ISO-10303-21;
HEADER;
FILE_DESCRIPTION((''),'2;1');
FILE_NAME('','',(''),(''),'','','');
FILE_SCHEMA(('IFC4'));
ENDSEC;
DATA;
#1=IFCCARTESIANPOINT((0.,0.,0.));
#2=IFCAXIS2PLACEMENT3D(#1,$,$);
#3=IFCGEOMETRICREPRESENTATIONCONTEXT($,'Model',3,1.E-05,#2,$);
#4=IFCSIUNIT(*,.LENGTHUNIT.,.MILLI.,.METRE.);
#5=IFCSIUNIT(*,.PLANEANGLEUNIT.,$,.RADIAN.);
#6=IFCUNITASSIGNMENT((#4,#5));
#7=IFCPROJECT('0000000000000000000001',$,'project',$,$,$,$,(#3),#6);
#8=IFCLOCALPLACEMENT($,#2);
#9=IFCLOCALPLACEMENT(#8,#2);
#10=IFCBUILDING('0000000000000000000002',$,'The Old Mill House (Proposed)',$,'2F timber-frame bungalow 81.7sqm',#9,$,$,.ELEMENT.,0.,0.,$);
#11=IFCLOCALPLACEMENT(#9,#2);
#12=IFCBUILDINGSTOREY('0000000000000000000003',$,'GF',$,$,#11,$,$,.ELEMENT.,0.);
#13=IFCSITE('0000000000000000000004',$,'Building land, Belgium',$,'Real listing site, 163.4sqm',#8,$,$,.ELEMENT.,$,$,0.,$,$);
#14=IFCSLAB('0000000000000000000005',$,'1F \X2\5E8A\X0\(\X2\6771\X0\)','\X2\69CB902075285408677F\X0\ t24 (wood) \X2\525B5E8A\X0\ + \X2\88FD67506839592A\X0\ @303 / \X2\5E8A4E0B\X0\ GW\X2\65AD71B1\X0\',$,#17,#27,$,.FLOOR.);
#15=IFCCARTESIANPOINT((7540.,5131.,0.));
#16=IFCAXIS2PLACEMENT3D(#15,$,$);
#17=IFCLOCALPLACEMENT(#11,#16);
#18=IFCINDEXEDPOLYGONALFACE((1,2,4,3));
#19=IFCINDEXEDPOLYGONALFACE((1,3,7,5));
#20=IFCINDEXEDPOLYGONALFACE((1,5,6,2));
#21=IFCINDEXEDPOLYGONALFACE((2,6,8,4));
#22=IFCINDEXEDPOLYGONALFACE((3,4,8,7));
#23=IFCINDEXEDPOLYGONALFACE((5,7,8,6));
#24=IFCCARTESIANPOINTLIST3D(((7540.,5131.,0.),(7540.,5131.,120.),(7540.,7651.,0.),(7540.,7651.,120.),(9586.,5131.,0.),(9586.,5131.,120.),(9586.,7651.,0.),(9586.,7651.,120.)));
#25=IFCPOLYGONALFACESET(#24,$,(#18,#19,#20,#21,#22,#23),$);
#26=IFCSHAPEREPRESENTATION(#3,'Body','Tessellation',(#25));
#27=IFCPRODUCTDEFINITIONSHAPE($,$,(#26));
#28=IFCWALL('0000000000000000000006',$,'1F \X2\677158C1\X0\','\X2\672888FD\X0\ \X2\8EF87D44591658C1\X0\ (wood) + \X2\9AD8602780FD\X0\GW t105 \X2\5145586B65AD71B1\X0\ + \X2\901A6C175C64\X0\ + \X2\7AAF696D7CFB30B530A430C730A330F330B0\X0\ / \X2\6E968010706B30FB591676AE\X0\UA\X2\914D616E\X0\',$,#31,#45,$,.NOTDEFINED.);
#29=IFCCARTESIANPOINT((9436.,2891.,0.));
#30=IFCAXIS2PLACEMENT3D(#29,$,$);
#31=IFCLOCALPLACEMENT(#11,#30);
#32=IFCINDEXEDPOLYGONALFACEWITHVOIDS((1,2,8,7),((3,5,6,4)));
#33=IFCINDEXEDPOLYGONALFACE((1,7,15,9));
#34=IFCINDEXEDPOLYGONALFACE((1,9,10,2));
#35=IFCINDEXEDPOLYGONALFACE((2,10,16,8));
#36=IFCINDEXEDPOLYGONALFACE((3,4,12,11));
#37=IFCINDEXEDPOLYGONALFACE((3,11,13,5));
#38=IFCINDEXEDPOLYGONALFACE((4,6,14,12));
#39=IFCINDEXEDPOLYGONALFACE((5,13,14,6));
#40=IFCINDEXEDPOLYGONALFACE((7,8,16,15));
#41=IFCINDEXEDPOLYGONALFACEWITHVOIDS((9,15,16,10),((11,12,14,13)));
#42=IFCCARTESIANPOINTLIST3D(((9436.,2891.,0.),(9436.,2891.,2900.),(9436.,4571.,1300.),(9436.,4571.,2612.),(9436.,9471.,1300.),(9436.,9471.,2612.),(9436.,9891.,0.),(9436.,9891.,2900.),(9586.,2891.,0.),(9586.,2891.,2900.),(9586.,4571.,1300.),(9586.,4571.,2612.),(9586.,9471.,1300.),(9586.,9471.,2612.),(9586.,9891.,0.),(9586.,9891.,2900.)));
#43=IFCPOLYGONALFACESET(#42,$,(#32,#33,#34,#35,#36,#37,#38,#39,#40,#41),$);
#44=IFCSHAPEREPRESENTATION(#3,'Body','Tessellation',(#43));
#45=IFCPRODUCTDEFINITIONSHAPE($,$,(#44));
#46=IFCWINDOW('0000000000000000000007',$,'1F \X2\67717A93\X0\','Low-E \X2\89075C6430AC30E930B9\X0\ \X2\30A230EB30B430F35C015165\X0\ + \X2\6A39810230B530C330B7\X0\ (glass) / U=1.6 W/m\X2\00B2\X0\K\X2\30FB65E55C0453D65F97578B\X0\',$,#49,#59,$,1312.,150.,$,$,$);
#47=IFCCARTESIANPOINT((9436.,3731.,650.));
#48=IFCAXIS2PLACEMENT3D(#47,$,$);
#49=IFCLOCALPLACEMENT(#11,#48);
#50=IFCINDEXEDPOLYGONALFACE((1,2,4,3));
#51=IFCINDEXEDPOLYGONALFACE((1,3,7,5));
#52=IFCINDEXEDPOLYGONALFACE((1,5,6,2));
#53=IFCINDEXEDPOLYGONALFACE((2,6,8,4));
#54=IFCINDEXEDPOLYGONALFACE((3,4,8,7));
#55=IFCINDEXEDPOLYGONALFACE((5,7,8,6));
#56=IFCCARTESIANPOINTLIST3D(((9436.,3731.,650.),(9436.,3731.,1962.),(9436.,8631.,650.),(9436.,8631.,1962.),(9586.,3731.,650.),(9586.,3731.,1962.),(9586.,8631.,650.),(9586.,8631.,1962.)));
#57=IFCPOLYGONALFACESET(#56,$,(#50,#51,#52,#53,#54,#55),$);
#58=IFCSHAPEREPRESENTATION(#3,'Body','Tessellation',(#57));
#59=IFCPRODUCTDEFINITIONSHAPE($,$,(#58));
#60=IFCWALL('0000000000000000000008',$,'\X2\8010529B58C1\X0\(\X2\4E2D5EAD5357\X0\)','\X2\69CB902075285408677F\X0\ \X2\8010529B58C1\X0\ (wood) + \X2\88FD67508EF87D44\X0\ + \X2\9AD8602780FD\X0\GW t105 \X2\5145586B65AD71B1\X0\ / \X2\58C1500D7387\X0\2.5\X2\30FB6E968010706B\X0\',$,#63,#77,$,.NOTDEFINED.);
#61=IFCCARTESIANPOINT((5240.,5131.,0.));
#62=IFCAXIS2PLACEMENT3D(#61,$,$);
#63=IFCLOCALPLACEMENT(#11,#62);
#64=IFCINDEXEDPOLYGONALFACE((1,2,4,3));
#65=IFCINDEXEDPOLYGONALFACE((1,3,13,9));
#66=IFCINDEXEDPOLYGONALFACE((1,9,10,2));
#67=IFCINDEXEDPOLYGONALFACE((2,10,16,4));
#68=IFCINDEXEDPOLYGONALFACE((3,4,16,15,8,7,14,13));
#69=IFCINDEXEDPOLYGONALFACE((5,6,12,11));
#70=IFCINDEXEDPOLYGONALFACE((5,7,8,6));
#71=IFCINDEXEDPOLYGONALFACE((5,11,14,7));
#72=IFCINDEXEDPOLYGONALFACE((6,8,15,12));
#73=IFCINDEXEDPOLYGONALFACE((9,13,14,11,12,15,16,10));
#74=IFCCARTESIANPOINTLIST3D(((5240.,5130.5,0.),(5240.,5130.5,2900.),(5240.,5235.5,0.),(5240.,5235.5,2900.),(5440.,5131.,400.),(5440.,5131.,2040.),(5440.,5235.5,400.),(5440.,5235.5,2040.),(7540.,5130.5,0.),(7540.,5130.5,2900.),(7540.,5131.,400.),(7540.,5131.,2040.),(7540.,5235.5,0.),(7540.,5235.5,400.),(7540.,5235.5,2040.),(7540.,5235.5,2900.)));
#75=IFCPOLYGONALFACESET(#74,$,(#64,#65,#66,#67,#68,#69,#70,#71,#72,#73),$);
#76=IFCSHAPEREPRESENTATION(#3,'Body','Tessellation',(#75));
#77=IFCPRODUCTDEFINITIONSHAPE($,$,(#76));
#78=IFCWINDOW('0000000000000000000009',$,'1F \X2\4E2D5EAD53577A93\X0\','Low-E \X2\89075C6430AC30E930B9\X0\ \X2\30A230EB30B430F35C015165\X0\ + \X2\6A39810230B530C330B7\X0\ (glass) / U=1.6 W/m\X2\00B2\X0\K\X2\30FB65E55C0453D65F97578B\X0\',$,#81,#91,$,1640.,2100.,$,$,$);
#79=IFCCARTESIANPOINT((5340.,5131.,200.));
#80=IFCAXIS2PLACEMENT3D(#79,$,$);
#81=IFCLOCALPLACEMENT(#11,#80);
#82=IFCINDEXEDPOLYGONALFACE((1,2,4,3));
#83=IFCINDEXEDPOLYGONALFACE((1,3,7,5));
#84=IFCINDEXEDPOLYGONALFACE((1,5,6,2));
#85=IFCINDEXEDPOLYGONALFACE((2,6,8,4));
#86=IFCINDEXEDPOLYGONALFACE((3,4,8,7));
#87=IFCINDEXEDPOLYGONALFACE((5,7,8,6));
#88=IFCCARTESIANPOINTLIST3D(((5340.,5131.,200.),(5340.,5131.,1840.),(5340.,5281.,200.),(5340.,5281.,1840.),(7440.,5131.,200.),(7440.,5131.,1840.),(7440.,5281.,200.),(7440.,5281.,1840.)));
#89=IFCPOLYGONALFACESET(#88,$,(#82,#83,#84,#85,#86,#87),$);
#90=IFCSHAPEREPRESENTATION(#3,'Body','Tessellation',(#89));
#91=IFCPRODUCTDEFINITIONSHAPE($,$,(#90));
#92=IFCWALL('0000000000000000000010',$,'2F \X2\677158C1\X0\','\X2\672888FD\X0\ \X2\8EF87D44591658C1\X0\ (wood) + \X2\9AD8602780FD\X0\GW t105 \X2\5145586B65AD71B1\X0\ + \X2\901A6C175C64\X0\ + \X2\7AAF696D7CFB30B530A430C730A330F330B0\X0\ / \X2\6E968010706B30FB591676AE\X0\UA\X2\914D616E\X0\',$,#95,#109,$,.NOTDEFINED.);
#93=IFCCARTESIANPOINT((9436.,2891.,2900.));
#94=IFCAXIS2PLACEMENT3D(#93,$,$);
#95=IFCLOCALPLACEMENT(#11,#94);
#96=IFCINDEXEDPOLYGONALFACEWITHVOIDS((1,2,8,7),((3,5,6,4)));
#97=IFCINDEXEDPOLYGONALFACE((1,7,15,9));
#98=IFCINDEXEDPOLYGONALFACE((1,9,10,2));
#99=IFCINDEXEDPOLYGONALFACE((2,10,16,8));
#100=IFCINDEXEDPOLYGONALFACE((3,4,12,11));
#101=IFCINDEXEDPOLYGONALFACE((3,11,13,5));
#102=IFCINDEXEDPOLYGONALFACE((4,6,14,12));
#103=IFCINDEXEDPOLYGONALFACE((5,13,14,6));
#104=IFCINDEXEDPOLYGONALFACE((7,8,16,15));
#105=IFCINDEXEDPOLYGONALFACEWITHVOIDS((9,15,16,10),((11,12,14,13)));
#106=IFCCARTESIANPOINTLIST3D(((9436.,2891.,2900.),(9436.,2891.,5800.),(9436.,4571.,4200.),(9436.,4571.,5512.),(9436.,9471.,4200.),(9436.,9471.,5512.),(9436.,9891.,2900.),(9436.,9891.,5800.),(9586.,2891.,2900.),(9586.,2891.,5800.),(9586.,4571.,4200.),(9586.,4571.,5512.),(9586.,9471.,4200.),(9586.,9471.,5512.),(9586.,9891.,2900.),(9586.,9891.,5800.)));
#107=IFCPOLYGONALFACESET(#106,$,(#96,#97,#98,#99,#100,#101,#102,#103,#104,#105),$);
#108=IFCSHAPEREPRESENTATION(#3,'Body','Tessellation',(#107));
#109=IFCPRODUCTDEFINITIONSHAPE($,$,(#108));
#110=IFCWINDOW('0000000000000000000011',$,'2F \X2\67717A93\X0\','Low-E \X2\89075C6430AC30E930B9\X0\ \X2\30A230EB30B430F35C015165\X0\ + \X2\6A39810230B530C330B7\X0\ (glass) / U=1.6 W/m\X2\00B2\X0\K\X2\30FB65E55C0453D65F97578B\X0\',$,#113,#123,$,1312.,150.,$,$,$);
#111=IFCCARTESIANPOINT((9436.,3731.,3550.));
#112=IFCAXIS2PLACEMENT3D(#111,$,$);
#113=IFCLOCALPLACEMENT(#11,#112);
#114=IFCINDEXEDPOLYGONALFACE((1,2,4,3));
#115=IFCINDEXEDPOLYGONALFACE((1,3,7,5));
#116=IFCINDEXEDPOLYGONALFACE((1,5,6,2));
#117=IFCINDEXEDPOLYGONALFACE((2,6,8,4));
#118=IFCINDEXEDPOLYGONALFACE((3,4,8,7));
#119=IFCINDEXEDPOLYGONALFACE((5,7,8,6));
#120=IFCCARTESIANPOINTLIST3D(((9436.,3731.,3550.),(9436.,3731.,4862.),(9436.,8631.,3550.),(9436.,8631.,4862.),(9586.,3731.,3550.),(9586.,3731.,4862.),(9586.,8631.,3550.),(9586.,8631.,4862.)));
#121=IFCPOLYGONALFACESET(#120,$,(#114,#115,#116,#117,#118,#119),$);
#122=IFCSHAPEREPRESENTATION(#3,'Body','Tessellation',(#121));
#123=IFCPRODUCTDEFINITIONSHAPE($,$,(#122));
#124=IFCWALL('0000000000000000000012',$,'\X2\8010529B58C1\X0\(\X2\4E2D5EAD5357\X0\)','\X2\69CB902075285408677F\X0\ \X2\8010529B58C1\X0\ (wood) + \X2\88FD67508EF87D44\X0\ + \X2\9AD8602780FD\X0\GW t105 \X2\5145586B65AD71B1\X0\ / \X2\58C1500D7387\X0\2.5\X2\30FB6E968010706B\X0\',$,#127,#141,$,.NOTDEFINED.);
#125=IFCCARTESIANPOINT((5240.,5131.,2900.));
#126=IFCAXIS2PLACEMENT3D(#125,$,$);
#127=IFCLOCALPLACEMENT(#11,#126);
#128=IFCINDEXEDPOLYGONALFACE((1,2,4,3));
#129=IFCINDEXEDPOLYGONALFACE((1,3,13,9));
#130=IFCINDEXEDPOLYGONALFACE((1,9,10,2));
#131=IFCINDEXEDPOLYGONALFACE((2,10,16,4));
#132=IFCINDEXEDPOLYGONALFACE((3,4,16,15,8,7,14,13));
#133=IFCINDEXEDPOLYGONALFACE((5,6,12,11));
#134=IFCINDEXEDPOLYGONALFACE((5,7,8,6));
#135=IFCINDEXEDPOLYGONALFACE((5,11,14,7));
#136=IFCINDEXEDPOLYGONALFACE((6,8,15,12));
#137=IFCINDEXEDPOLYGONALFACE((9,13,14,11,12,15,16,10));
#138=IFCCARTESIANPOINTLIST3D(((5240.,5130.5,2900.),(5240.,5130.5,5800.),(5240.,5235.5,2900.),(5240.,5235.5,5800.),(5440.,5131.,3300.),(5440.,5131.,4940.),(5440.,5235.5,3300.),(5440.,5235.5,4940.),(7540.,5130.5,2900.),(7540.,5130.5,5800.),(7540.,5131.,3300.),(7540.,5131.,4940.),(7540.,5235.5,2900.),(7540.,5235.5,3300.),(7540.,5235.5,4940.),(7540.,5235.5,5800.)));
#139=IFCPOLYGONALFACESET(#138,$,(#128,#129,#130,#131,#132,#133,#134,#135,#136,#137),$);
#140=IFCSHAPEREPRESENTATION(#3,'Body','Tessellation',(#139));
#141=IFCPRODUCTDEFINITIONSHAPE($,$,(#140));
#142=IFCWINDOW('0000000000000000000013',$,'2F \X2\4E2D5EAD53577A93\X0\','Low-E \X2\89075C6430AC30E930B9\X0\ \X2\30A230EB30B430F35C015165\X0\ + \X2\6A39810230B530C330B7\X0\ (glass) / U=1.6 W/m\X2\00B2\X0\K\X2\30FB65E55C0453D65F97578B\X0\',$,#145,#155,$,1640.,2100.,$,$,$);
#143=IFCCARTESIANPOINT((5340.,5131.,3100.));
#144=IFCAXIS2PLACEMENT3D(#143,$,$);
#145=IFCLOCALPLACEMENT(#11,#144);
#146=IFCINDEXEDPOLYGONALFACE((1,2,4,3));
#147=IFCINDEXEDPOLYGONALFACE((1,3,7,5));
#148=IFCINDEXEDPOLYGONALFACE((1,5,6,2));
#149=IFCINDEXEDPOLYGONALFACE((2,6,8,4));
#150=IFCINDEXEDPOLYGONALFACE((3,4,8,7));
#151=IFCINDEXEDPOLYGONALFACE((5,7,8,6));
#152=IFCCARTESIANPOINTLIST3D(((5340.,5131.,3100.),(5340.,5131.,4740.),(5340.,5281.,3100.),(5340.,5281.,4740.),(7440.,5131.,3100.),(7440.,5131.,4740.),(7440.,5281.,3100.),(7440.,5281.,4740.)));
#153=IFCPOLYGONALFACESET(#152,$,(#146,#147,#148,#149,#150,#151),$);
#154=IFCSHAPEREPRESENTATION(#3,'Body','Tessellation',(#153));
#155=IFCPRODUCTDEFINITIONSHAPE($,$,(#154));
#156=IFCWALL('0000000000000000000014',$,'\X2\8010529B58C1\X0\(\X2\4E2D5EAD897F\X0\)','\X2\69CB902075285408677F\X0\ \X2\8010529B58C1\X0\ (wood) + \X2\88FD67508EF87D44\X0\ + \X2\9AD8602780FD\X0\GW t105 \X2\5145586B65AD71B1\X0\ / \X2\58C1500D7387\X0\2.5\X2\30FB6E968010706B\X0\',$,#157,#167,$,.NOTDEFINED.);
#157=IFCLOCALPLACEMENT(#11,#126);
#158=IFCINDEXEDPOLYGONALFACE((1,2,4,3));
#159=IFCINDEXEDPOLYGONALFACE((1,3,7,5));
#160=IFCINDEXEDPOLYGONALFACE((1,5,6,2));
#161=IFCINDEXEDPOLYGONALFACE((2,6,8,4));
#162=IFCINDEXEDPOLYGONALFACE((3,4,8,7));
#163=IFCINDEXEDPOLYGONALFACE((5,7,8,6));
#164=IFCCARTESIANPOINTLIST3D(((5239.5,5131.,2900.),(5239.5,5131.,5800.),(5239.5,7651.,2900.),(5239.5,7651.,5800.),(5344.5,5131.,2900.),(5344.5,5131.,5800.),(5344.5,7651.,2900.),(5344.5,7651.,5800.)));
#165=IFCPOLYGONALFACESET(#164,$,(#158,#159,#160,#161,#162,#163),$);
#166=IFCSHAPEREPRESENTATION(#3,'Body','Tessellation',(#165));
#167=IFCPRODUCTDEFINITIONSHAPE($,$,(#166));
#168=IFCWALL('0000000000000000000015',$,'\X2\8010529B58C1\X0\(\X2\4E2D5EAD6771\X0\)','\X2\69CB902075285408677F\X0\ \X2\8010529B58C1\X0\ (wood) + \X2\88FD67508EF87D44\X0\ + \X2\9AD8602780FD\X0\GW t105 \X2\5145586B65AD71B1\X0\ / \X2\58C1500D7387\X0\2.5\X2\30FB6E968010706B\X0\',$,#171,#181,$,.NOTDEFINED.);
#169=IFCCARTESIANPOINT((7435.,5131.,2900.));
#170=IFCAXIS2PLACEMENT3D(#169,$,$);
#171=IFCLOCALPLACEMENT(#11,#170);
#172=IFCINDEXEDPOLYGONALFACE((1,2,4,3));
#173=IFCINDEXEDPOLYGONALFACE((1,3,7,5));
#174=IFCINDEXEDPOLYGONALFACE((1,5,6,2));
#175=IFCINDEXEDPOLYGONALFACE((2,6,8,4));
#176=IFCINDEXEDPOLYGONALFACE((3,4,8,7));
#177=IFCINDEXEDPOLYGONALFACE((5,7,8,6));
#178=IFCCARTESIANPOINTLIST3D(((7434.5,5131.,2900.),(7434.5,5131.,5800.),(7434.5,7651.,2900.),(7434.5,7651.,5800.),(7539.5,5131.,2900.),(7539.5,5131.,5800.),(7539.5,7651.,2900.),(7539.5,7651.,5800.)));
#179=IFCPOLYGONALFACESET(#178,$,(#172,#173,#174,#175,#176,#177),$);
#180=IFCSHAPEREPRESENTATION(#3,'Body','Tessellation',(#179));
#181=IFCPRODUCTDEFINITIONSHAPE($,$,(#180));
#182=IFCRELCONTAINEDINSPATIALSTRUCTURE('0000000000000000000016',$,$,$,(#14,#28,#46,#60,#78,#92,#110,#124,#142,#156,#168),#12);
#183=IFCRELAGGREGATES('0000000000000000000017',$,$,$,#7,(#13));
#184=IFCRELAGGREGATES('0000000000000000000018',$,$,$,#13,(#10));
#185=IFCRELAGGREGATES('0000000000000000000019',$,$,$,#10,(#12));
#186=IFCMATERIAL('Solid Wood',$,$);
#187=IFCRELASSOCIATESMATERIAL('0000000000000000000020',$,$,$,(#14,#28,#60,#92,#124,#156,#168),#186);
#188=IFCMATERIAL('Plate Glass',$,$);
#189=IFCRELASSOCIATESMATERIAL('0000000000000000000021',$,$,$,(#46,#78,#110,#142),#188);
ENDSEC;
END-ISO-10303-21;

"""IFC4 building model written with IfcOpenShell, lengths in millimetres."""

from ifc_helpers import new_model, si_unit, frame, frame_2d, origin, place, context, project, spatial, rectangle, extrude, material, element, fill, save


model = new_model("IFC4")

# Units and contexts
model_context = context("Model", 3, precision=1e-05, world=origin())
ifc_project = project(units=[si_unit("LENGTHUNIT", "METRE", prefix="MILLI"), si_unit("PLANEANGLEUNIT", "RADIAN")], contexts=[model_context])

# Site, building, storey
site_placement = place(None, origin())
site = spatial("IfcSite", under=ifc_project, at=site_placement, Name="Building land, Belgium", ObjectType="Real listing site, 163.4sqm", CompositionType="ELEMENT", RefElevation=0.0)
building_placement = place(site_placement, origin())
building = spatial("IfcBuilding", under=site, at=building_placement, Name="The Old Mill House (Proposed)", ObjectType="2F timber-frame bungalow 81.7sqm", CompositionType="ELEMENT", ElevationOfRefHeight=0.0, ElevationOfTerrain=0.0)
storey_placement = place(building_placement, origin())
storey = spatial("IfcBuildingStorey", under=building, at=storey_placement, Name="GF", CompositionType="ELEMENT", Elevation=0.0)

# Slab
ifc_material_1 = material(Name="Solid Wood")
slab_placement = place(storey_placement, frame((7540.0, 5131.0, 0.0)))
element("IfcSlab", 1, at=slab_placement, inside=storey, material=ifc_material_1, Name="1F 床(東)", Description="構造用合板 t24 (wood) 剛床 + 製材根太 @303 / 床下 GW断熱", PredefinedType="FLOOR", context=model_context, shape_type="SweptSolid", body=[
    extrude(rectangle(XDim=2046.0, YDim=2520.0, at=frame_2d((1023.0, 1260.0))), frame((7540.0, 5131.0, 0.0)), (0.0, 0.0, 1.0), 120.0),
])

# Walls, openings, windows
wall_1_placement = place(storey_placement, frame((9436.0, 2891.0, 0.0)))
wall_1 = element("IfcWall", 2, at=wall_1_placement, inside=storey, material=ifc_material_1, Name="1F 東壁", Description="木製 軸組外壁 (wood) + 高性能GW t105 充填断熱 + 通気層 + 窯業系サイディング / 準耐火・外皮UA配慮", PredefinedType="NOTDEFINED", context=model_context, shape_type="SweptSolid", body=[
    extrude(rectangle(XDim=150.0, YDim=7000.0, at=frame_2d((75.0, 3500.0))), frame((9436.0, 2891.0, 0.0)), (0.0, 0.0, 1.0), 2900.0),
])
opening_1_placement = place(storey_placement, frame((9436.0, 3731.0, 650.0)))
opening_1 = element("IfcOpeningElement", 3, at=opening_1_placement, cuts=wall_1, PredefinedType="NOTDEFINED", context=model_context, shape_type="SweptSolid", body=[
    extrude(rectangle(XDim=150.0, YDim=4900.0, at=frame_2d((75.0, 2450.0))), frame((9436.0, 3731.0, 650.0)), (0.0, 0.0, 1.0), 1312.0),
])
ifc_material_2 = material(Name="Plate Glass")
window_1_placement = place(storey_placement, frame((9436.0, 3731.0, 650.0)))
window_1 = element("IfcWindow", 4, at=window_1_placement, inside=storey, material=ifc_material_2, Name="1F 東窓", Description="Low-E 複層ガラス アルゴン封入 + 樹脂サッシ (glass) / U=1.6 W/m²K・日射取得型", OverallHeight=1312.0, OverallWidth=150.0, context=model_context, shape_type="SweptSolid", body=[
    extrude(rectangle(XDim=150.0, YDim=4900.0, at=frame_2d((75.0, 2450.0))), frame((9436.0, 3731.0, 650.0)), (0.0, 0.0, 1.0), 1312.0),
])
fill(opening_1, window_1)
wall_2_placement = place(storey_placement, frame((5240.0, 5131.0, 0.0)))
wall_2 = element("IfcWall", 5, at=wall_2_placement, inside=storey, material=ifc_material_1, Name="耐力壁(中庭南)", Description="構造用合板 耐力壁 (wood) + 製材軸組 + 高性能GW t105 充填断熱 / 壁倍率2.5・準耐火", PredefinedType="NOTDEFINED", context=model_context, shape_type="SweptSolid", body=[
    extrude(rectangle(XDim=2300.0, YDim=105.0, at=frame_2d((1150.0, 52.0))), frame((5240.0, 5131.0, 0.0)), (0.0, 0.0, 1.0), 2900.0),
])
opening_2_placement = place(storey_placement, frame((5340.0, 5131.0, 200.0)))
opening_2 = element("IfcOpeningElement", 6, at=opening_2_placement, cuts=wall_2, PredefinedType="NOTDEFINED", context=model_context, shape_type="SweptSolid", body=[
    extrude(rectangle(XDim=2100.0, YDim=150.0, at=frame_2d((1050.0, 75.0))), frame((5340.0, 5131.0, 200.0)), (0.0, 0.0, 1.0), 1640.0),
])
window_2_placement = place(storey_placement, frame((5340.0, 5131.0, 200.0)))
window_2 = element("IfcWindow", 7, at=window_2_placement, inside=storey, material=ifc_material_2, Name="1F 中庭南窓", Description="Low-E 複層ガラス アルゴン封入 + 樹脂サッシ (glass) / U=1.6 W/m²K・日射取得型", OverallHeight=1640.0, OverallWidth=2100.0, context=model_context, shape_type="SweptSolid", body=[
    extrude(rectangle(XDim=2100.0, YDim=150.0, at=frame_2d((1050.0, 75.0))), frame((5340.0, 5131.0, 200.0)), (0.0, 0.0, 1.0), 1640.0),
])
fill(opening_2, window_2)

# Walls, openings, windows
wall_3_placement = place(storey_placement, frame((9436.0, 2891.0, 2900.0)))
wall_3 = element("IfcWall", 8, at=wall_3_placement, inside=storey, material=ifc_material_1, Name="2F 東壁", Description="木製 軸組外壁 (wood) + 高性能GW t105 充填断熱 + 通気層 + 窯業系サイディング / 準耐火・外皮UA配慮", PredefinedType="NOTDEFINED", context=model_context, shape_type="SweptSolid", body=[
    extrude(rectangle(XDim=150.0, YDim=7000.0, at=frame_2d((75.0, 3500.0))), frame((9436.0, 2891.0, 2900.0)), (0.0, 0.0, 1.0), 2900.0),
])
opening_3_placement = place(storey_placement, frame((9436.0, 3731.0, 3550.0)))
opening_3 = element("IfcOpeningElement", 9, at=opening_3_placement, cuts=wall_3, PredefinedType="NOTDEFINED", context=model_context, shape_type="SweptSolid", body=[
    extrude(rectangle(XDim=150.0, YDim=4900.0, at=frame_2d((75.0, 2450.0))), frame((9436.0, 3731.0, 3550.0)), (0.0, 0.0, 1.0), 1312.0),
])
window_3_placement = place(storey_placement, frame((9436.0, 3731.0, 3550.0)))
window_3 = element("IfcWindow", 10, at=window_3_placement, inside=storey, material=ifc_material_2, Name="2F 東窓", Description="Low-E 複層ガラス アルゴン封入 + 樹脂サッシ (glass) / U=1.6 W/m²K・日射取得型", OverallHeight=1312.0, OverallWidth=150.0, context=model_context, shape_type="SweptSolid", body=[
    extrude(rectangle(XDim=150.0, YDim=4900.0, at=frame_2d((75.0, 2450.0))), frame((9436.0, 3731.0, 3550.0)), (0.0, 0.0, 1.0), 1312.0),
])
fill(opening_3, window_3)
wall_4_placement = place(storey_placement, frame((5240.0, 5131.0, 2900.0)))
wall_4 = element("IfcWall", 11, at=wall_4_placement, inside=storey, material=ifc_material_1, Name="耐力壁(中庭南)", Description="構造用合板 耐力壁 (wood) + 製材軸組 + 高性能GW t105 充填断熱 / 壁倍率2.5・準耐火", PredefinedType="NOTDEFINED", context=model_context, shape_type="SweptSolid", body=[
    extrude(rectangle(XDim=2300.0, YDim=105.0, at=frame_2d((1150.0, 52.0))), frame((5240.0, 5131.0, 2900.0)), (0.0, 0.0, 1.0), 2900.0),
])
opening_4_placement = place(storey_placement, frame((5340.0, 5131.0, 3100.0)))
opening_4 = element("IfcOpeningElement", 12, at=opening_4_placement, cuts=wall_4, PredefinedType="NOTDEFINED", context=model_context, shape_type="SweptSolid", body=[
    extrude(rectangle(XDim=2100.0, YDim=150.0, at=frame_2d((1050.0, 75.0))), frame((5340.0, 5131.0, 3100.0)), (0.0, 0.0, 1.0), 1640.0),
])
window_4_placement = place(storey_placement, frame((5340.0, 5131.0, 3100.0)))
window_4 = element("IfcWindow", 13, at=window_4_placement, inside=storey, material=ifc_material_2, Name="2F 中庭南窓", Description="Low-E 複層ガラス アルゴン封入 + 樹脂サッシ (glass) / U=1.6 W/m²K・日射取得型", OverallHeight=1640.0, OverallWidth=2100.0, context=model_context, shape_type="SweptSolid", body=[
    extrude(rectangle(XDim=2100.0, YDim=150.0, at=frame_2d((1050.0, 75.0))), frame((5340.0, 5131.0, 3100.0)), (0.0, 0.0, 1.0), 1640.0),
])
fill(opening_4, window_4)

# Walls
wall_5_placement = place(storey_placement, frame((5240.0, 5131.0, 2900.0)))
element("IfcWall", 14, at=wall_5_placement, inside=storey, material=ifc_material_1, Name="耐力壁(中庭西)", Description="構造用合板 耐力壁 (wood) + 製材軸組 + 高性能GW t105 充填断熱 / 壁倍率2.5・準耐火", PredefinedType="NOTDEFINED", context=model_context, shape_type="SweptSolid", body=[
    extrude(rectangle(XDim=105.0, YDim=2520.0, at=frame_2d((52.0, 1260.0))), frame((5240.0, 5131.0, 2900.0)), (0.0, 0.0, 1.0), 2900.0),
])
wall_6_placement = place(storey_placement, frame((7435.0, 5131.0, 2900.0)))
element("IfcWall", 15, at=wall_6_placement, inside=storey, material=ifc_material_1, Name="耐力壁(中庭東)", Description="構造用合板 耐力壁 (wood) + 製材軸組 + 高性能GW t105 充填断熱 / 壁倍率2.5・準耐火", PredefinedType="NOTDEFINED", context=model_context, shape_type="SweptSolid", body=[
    extrude(rectangle(XDim=105.0, YDim=2520.0, at=frame_2d((52.0, 1260.0))), frame((7435.0, 5131.0, 2900.0)), (0.0, 0.0, 1.0), 2900.0),
])

save(model, "model.ifc")
